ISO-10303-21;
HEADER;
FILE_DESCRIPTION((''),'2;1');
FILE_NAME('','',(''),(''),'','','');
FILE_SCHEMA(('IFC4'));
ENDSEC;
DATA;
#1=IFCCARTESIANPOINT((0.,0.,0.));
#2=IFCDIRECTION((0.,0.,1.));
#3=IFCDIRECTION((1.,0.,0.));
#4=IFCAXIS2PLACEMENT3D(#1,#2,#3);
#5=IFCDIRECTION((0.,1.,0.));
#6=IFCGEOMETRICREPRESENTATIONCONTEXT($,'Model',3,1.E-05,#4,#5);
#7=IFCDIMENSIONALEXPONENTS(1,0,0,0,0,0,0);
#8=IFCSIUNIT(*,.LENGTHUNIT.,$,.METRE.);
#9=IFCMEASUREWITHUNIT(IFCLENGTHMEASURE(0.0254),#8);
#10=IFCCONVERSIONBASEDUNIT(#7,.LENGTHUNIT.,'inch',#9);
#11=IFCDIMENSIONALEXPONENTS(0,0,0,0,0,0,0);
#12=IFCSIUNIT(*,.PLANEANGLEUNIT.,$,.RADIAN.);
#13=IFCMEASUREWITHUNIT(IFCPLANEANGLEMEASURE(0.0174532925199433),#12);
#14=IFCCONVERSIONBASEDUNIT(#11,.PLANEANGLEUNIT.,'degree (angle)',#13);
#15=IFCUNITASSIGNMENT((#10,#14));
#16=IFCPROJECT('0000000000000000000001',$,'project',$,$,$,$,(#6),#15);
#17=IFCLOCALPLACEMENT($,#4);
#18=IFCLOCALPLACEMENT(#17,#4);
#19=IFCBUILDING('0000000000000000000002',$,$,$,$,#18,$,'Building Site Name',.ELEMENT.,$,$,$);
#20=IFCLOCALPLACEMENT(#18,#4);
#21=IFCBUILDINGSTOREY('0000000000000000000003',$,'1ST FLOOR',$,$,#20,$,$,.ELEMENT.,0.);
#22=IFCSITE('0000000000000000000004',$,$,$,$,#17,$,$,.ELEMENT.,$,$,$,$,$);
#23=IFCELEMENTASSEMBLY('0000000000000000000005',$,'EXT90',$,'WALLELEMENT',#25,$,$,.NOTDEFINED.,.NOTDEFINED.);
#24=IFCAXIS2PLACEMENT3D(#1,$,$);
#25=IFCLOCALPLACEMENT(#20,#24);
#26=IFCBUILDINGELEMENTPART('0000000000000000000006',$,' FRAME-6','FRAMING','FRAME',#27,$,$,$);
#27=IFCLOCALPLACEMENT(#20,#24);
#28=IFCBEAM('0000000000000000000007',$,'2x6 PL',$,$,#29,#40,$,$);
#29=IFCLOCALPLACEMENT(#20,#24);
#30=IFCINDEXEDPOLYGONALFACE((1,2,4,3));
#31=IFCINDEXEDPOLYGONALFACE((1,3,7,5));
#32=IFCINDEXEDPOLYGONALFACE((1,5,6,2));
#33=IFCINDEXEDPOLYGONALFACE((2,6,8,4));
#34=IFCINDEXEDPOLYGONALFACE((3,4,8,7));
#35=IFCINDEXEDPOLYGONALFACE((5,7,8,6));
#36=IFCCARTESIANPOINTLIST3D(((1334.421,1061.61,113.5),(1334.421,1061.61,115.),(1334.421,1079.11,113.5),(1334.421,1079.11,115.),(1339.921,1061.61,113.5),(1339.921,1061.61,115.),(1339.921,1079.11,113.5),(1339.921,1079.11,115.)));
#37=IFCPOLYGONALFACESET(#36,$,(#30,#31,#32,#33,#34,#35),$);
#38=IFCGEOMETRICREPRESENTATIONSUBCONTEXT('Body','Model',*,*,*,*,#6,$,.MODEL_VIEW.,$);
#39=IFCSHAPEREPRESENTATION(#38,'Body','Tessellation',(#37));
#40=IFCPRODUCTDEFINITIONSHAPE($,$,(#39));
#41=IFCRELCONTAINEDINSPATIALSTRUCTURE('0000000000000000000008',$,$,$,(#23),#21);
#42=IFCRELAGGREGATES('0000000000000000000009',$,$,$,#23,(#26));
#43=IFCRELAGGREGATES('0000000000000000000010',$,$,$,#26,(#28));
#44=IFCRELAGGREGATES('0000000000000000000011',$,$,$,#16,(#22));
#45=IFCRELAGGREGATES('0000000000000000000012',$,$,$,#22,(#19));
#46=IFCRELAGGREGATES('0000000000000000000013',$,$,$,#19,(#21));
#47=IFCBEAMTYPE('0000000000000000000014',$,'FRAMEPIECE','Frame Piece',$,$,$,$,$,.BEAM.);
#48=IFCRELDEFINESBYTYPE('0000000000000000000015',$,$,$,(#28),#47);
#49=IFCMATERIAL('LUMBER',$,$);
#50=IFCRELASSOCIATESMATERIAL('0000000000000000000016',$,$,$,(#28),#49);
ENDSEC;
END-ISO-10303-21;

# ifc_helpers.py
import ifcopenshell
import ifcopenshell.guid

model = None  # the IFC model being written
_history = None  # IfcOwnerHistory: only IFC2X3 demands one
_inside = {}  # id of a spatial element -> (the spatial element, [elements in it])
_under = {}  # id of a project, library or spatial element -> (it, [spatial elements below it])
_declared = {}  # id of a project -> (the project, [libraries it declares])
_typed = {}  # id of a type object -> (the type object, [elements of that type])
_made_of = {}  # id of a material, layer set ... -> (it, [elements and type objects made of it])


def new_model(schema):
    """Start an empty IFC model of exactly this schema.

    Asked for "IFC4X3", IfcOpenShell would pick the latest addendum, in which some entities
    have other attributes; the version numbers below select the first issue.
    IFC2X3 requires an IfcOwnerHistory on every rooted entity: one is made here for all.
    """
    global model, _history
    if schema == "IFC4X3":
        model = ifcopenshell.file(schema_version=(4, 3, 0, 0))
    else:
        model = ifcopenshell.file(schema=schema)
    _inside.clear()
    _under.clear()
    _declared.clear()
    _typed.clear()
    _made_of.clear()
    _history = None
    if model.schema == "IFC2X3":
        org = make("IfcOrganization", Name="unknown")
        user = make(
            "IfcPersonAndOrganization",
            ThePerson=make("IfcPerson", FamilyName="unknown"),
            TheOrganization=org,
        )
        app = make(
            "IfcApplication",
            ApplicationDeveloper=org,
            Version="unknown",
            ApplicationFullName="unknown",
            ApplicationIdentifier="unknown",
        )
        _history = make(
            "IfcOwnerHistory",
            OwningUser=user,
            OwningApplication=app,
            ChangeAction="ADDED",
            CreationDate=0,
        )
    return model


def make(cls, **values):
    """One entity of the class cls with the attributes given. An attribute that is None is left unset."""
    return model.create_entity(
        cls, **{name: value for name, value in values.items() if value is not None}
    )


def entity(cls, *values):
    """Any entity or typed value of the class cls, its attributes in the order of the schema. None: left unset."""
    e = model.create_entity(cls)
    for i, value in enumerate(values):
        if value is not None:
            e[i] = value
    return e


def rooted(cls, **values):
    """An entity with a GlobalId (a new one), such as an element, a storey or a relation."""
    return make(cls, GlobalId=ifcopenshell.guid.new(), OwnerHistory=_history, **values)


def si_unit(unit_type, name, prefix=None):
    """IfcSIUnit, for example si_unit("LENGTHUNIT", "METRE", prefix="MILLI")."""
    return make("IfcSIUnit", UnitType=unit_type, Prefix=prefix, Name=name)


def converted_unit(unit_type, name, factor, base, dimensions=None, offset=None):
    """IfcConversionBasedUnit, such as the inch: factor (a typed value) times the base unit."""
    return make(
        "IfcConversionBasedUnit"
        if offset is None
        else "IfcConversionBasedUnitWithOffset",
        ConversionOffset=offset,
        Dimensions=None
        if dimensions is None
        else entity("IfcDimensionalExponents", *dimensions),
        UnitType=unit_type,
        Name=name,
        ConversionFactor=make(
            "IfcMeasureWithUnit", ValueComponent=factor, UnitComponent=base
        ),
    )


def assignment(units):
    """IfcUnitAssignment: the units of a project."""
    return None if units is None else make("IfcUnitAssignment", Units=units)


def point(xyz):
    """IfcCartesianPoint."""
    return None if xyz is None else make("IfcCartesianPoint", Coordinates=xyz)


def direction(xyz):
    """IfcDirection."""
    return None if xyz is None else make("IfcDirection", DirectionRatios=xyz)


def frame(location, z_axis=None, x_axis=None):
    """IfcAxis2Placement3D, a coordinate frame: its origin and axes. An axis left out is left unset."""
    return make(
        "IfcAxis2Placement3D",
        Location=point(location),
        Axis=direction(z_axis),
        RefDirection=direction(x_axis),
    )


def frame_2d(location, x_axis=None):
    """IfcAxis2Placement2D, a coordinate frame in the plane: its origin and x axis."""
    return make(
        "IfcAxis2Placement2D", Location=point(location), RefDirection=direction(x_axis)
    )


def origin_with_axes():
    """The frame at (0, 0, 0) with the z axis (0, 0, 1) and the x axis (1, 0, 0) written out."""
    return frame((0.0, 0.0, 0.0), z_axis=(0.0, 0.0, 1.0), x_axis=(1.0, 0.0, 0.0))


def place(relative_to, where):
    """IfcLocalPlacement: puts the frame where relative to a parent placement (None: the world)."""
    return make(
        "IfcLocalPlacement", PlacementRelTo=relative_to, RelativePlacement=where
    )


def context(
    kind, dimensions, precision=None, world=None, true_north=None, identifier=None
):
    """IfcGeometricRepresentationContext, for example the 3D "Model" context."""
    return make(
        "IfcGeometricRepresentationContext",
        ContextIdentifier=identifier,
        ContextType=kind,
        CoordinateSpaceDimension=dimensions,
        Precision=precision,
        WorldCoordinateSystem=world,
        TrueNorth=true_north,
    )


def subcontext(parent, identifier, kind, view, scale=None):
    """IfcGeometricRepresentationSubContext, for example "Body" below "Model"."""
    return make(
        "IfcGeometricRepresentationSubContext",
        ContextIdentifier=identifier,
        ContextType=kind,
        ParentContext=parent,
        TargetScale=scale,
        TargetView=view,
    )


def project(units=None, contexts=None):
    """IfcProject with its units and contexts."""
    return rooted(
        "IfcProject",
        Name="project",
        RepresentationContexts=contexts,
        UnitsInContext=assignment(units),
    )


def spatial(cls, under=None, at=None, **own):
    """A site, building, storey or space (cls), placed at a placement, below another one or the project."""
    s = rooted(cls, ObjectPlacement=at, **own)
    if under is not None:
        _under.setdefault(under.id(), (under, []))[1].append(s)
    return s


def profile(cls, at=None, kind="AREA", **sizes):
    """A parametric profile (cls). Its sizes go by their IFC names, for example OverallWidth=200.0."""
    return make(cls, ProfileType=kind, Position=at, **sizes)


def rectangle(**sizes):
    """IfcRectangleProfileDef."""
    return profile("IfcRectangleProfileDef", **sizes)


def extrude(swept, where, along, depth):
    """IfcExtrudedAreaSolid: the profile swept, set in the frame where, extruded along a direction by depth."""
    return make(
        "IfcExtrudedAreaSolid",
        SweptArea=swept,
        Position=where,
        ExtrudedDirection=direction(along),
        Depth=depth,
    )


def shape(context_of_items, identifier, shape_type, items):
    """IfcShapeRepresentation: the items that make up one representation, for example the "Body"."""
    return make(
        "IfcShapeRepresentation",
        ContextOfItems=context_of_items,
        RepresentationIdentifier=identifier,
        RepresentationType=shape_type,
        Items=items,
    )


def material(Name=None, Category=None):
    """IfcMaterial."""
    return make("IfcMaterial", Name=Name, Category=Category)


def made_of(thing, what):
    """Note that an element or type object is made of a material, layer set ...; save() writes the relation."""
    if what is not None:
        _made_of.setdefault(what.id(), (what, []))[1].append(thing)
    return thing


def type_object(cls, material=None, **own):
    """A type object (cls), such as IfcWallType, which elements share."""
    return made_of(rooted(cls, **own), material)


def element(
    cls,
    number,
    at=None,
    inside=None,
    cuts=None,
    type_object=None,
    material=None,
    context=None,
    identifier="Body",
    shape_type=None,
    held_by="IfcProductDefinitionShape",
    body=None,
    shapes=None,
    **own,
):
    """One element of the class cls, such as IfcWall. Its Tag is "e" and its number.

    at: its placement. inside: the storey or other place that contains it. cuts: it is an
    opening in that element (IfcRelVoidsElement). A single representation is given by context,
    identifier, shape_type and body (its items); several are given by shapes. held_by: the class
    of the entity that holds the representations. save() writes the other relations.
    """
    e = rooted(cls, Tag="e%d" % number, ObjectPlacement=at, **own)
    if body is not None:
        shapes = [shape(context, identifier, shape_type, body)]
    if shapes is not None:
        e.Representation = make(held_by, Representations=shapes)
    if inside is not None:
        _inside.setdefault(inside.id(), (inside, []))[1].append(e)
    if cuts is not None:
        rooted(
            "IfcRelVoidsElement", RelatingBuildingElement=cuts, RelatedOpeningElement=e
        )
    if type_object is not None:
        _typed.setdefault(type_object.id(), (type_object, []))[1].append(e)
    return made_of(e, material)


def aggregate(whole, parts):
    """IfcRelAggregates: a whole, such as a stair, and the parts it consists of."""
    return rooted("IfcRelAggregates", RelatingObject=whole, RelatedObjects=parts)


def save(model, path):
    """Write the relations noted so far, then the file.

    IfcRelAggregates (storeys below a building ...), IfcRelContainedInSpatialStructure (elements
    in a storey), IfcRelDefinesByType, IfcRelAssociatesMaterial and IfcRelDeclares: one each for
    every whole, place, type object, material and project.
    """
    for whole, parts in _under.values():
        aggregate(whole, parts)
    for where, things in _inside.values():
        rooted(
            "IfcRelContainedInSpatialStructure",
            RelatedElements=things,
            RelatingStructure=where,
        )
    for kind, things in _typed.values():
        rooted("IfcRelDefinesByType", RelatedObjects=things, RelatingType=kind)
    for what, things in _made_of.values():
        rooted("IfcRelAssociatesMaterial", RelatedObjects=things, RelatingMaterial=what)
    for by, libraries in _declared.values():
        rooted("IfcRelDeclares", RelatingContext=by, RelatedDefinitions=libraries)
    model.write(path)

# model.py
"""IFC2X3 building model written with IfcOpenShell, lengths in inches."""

from ifc_helpers import new_model, entity, si_unit, converted_unit, direction, frame, frame_2d, origin_with_axes, place, context, subcontext, project, spatial, rectangle, extrude, material, type_object, element, aggregate, save


model = new_model("IFC2X3")

# Units and contexts
model_context = context("Model", 3, precision=1e-05, world=origin_with_axes(), true_north=direction((0.0, 1.0, 0.0)))
body_context = subcontext(model_context, "Body", "Model", "MODEL_VIEW")
ifc_project = project(units=[converted_unit("LENGTHUNIT", "inch", entity("IfcLengthMeasure", 0.0254), si_unit("LENGTHUNIT", "METRE"), dimensions=[1, 0, 0, 0, 0, 0, 0]), converted_unit("PLANEANGLEUNIT", "degree (angle)", entity("IfcPlaneAngleMeasure", 0.0174532925199433), si_unit("PLANEANGLEUNIT", "RADIAN"), dimensions=[0, 0, 0, 0, 0, 0, 0])], contexts=[model_context])

# Site, building, storey
site_placement = place(None, origin_with_axes())
site = spatial("IfcSite", under=ifc_project, at=site_placement, CompositionType="ELEMENT")
building_placement = place(site_placement, origin_with_axes())
building = spatial("IfcBuilding", under=site, at=building_placement, LongName="Building Site Name", CompositionType="ELEMENT")
storey_placement = place(building_placement, origin_with_axes())
storey = spatial("IfcBuildingStorey", under=building, at=storey_placement, Name="1ST FLOOR", CompositionType="ELEMENT", Elevation=0.0)

# Shared definitions
ifc_material_1 = material(Name="LUMBER")
beam_type = type_object("IfcBeamType", Name="FRAMEPIECE", Description="Frame Piece", PredefinedType="BEAM")

# Element assembly, building element part, beam
assembly_1_placement = place(storey_placement, origin_with_axes())
assembly_1 = element("IfcElementAssembly", 1, at=assembly_1_placement, inside=storey, Name="EXT90", ObjectType="WALLELEMENT", AssemblyPlace="NOTDEFINED", PredefinedType="NOTDEFINED")
building_element_part_1 = element("IfcBuildingElementPart", 2, Name=" FRAME-6", Description="FRAMING", ObjectType="FRAME")
aggregate(assembly_1, [building_element_part_1])
beam_1_placement = place(assembly_1_placement, frame((1337.171, 1061.61, 114.25), z_axis=(0.0, 1.0, 0.0), x_axis=(0.0, 0.0, -1.0)))
beam_1 = element("IfcBeam", 3, at=beam_1_placement, type_object=beam_type, material=ifc_material_1, Name="2x6 PL", context=body_context, shape_type="SweptSolid", body=[
    extrude(rectangle(XDim=1.5, YDim=5.5, at=frame_2d((0.0, 0.0), x_axis=(-1.0, 0.0))), origin_with_axes(), (0.0, 0.0, 1.0), 17.5),
])
aggregate(building_element_part_1, [beam_1])

save(model, "model.ifc")
